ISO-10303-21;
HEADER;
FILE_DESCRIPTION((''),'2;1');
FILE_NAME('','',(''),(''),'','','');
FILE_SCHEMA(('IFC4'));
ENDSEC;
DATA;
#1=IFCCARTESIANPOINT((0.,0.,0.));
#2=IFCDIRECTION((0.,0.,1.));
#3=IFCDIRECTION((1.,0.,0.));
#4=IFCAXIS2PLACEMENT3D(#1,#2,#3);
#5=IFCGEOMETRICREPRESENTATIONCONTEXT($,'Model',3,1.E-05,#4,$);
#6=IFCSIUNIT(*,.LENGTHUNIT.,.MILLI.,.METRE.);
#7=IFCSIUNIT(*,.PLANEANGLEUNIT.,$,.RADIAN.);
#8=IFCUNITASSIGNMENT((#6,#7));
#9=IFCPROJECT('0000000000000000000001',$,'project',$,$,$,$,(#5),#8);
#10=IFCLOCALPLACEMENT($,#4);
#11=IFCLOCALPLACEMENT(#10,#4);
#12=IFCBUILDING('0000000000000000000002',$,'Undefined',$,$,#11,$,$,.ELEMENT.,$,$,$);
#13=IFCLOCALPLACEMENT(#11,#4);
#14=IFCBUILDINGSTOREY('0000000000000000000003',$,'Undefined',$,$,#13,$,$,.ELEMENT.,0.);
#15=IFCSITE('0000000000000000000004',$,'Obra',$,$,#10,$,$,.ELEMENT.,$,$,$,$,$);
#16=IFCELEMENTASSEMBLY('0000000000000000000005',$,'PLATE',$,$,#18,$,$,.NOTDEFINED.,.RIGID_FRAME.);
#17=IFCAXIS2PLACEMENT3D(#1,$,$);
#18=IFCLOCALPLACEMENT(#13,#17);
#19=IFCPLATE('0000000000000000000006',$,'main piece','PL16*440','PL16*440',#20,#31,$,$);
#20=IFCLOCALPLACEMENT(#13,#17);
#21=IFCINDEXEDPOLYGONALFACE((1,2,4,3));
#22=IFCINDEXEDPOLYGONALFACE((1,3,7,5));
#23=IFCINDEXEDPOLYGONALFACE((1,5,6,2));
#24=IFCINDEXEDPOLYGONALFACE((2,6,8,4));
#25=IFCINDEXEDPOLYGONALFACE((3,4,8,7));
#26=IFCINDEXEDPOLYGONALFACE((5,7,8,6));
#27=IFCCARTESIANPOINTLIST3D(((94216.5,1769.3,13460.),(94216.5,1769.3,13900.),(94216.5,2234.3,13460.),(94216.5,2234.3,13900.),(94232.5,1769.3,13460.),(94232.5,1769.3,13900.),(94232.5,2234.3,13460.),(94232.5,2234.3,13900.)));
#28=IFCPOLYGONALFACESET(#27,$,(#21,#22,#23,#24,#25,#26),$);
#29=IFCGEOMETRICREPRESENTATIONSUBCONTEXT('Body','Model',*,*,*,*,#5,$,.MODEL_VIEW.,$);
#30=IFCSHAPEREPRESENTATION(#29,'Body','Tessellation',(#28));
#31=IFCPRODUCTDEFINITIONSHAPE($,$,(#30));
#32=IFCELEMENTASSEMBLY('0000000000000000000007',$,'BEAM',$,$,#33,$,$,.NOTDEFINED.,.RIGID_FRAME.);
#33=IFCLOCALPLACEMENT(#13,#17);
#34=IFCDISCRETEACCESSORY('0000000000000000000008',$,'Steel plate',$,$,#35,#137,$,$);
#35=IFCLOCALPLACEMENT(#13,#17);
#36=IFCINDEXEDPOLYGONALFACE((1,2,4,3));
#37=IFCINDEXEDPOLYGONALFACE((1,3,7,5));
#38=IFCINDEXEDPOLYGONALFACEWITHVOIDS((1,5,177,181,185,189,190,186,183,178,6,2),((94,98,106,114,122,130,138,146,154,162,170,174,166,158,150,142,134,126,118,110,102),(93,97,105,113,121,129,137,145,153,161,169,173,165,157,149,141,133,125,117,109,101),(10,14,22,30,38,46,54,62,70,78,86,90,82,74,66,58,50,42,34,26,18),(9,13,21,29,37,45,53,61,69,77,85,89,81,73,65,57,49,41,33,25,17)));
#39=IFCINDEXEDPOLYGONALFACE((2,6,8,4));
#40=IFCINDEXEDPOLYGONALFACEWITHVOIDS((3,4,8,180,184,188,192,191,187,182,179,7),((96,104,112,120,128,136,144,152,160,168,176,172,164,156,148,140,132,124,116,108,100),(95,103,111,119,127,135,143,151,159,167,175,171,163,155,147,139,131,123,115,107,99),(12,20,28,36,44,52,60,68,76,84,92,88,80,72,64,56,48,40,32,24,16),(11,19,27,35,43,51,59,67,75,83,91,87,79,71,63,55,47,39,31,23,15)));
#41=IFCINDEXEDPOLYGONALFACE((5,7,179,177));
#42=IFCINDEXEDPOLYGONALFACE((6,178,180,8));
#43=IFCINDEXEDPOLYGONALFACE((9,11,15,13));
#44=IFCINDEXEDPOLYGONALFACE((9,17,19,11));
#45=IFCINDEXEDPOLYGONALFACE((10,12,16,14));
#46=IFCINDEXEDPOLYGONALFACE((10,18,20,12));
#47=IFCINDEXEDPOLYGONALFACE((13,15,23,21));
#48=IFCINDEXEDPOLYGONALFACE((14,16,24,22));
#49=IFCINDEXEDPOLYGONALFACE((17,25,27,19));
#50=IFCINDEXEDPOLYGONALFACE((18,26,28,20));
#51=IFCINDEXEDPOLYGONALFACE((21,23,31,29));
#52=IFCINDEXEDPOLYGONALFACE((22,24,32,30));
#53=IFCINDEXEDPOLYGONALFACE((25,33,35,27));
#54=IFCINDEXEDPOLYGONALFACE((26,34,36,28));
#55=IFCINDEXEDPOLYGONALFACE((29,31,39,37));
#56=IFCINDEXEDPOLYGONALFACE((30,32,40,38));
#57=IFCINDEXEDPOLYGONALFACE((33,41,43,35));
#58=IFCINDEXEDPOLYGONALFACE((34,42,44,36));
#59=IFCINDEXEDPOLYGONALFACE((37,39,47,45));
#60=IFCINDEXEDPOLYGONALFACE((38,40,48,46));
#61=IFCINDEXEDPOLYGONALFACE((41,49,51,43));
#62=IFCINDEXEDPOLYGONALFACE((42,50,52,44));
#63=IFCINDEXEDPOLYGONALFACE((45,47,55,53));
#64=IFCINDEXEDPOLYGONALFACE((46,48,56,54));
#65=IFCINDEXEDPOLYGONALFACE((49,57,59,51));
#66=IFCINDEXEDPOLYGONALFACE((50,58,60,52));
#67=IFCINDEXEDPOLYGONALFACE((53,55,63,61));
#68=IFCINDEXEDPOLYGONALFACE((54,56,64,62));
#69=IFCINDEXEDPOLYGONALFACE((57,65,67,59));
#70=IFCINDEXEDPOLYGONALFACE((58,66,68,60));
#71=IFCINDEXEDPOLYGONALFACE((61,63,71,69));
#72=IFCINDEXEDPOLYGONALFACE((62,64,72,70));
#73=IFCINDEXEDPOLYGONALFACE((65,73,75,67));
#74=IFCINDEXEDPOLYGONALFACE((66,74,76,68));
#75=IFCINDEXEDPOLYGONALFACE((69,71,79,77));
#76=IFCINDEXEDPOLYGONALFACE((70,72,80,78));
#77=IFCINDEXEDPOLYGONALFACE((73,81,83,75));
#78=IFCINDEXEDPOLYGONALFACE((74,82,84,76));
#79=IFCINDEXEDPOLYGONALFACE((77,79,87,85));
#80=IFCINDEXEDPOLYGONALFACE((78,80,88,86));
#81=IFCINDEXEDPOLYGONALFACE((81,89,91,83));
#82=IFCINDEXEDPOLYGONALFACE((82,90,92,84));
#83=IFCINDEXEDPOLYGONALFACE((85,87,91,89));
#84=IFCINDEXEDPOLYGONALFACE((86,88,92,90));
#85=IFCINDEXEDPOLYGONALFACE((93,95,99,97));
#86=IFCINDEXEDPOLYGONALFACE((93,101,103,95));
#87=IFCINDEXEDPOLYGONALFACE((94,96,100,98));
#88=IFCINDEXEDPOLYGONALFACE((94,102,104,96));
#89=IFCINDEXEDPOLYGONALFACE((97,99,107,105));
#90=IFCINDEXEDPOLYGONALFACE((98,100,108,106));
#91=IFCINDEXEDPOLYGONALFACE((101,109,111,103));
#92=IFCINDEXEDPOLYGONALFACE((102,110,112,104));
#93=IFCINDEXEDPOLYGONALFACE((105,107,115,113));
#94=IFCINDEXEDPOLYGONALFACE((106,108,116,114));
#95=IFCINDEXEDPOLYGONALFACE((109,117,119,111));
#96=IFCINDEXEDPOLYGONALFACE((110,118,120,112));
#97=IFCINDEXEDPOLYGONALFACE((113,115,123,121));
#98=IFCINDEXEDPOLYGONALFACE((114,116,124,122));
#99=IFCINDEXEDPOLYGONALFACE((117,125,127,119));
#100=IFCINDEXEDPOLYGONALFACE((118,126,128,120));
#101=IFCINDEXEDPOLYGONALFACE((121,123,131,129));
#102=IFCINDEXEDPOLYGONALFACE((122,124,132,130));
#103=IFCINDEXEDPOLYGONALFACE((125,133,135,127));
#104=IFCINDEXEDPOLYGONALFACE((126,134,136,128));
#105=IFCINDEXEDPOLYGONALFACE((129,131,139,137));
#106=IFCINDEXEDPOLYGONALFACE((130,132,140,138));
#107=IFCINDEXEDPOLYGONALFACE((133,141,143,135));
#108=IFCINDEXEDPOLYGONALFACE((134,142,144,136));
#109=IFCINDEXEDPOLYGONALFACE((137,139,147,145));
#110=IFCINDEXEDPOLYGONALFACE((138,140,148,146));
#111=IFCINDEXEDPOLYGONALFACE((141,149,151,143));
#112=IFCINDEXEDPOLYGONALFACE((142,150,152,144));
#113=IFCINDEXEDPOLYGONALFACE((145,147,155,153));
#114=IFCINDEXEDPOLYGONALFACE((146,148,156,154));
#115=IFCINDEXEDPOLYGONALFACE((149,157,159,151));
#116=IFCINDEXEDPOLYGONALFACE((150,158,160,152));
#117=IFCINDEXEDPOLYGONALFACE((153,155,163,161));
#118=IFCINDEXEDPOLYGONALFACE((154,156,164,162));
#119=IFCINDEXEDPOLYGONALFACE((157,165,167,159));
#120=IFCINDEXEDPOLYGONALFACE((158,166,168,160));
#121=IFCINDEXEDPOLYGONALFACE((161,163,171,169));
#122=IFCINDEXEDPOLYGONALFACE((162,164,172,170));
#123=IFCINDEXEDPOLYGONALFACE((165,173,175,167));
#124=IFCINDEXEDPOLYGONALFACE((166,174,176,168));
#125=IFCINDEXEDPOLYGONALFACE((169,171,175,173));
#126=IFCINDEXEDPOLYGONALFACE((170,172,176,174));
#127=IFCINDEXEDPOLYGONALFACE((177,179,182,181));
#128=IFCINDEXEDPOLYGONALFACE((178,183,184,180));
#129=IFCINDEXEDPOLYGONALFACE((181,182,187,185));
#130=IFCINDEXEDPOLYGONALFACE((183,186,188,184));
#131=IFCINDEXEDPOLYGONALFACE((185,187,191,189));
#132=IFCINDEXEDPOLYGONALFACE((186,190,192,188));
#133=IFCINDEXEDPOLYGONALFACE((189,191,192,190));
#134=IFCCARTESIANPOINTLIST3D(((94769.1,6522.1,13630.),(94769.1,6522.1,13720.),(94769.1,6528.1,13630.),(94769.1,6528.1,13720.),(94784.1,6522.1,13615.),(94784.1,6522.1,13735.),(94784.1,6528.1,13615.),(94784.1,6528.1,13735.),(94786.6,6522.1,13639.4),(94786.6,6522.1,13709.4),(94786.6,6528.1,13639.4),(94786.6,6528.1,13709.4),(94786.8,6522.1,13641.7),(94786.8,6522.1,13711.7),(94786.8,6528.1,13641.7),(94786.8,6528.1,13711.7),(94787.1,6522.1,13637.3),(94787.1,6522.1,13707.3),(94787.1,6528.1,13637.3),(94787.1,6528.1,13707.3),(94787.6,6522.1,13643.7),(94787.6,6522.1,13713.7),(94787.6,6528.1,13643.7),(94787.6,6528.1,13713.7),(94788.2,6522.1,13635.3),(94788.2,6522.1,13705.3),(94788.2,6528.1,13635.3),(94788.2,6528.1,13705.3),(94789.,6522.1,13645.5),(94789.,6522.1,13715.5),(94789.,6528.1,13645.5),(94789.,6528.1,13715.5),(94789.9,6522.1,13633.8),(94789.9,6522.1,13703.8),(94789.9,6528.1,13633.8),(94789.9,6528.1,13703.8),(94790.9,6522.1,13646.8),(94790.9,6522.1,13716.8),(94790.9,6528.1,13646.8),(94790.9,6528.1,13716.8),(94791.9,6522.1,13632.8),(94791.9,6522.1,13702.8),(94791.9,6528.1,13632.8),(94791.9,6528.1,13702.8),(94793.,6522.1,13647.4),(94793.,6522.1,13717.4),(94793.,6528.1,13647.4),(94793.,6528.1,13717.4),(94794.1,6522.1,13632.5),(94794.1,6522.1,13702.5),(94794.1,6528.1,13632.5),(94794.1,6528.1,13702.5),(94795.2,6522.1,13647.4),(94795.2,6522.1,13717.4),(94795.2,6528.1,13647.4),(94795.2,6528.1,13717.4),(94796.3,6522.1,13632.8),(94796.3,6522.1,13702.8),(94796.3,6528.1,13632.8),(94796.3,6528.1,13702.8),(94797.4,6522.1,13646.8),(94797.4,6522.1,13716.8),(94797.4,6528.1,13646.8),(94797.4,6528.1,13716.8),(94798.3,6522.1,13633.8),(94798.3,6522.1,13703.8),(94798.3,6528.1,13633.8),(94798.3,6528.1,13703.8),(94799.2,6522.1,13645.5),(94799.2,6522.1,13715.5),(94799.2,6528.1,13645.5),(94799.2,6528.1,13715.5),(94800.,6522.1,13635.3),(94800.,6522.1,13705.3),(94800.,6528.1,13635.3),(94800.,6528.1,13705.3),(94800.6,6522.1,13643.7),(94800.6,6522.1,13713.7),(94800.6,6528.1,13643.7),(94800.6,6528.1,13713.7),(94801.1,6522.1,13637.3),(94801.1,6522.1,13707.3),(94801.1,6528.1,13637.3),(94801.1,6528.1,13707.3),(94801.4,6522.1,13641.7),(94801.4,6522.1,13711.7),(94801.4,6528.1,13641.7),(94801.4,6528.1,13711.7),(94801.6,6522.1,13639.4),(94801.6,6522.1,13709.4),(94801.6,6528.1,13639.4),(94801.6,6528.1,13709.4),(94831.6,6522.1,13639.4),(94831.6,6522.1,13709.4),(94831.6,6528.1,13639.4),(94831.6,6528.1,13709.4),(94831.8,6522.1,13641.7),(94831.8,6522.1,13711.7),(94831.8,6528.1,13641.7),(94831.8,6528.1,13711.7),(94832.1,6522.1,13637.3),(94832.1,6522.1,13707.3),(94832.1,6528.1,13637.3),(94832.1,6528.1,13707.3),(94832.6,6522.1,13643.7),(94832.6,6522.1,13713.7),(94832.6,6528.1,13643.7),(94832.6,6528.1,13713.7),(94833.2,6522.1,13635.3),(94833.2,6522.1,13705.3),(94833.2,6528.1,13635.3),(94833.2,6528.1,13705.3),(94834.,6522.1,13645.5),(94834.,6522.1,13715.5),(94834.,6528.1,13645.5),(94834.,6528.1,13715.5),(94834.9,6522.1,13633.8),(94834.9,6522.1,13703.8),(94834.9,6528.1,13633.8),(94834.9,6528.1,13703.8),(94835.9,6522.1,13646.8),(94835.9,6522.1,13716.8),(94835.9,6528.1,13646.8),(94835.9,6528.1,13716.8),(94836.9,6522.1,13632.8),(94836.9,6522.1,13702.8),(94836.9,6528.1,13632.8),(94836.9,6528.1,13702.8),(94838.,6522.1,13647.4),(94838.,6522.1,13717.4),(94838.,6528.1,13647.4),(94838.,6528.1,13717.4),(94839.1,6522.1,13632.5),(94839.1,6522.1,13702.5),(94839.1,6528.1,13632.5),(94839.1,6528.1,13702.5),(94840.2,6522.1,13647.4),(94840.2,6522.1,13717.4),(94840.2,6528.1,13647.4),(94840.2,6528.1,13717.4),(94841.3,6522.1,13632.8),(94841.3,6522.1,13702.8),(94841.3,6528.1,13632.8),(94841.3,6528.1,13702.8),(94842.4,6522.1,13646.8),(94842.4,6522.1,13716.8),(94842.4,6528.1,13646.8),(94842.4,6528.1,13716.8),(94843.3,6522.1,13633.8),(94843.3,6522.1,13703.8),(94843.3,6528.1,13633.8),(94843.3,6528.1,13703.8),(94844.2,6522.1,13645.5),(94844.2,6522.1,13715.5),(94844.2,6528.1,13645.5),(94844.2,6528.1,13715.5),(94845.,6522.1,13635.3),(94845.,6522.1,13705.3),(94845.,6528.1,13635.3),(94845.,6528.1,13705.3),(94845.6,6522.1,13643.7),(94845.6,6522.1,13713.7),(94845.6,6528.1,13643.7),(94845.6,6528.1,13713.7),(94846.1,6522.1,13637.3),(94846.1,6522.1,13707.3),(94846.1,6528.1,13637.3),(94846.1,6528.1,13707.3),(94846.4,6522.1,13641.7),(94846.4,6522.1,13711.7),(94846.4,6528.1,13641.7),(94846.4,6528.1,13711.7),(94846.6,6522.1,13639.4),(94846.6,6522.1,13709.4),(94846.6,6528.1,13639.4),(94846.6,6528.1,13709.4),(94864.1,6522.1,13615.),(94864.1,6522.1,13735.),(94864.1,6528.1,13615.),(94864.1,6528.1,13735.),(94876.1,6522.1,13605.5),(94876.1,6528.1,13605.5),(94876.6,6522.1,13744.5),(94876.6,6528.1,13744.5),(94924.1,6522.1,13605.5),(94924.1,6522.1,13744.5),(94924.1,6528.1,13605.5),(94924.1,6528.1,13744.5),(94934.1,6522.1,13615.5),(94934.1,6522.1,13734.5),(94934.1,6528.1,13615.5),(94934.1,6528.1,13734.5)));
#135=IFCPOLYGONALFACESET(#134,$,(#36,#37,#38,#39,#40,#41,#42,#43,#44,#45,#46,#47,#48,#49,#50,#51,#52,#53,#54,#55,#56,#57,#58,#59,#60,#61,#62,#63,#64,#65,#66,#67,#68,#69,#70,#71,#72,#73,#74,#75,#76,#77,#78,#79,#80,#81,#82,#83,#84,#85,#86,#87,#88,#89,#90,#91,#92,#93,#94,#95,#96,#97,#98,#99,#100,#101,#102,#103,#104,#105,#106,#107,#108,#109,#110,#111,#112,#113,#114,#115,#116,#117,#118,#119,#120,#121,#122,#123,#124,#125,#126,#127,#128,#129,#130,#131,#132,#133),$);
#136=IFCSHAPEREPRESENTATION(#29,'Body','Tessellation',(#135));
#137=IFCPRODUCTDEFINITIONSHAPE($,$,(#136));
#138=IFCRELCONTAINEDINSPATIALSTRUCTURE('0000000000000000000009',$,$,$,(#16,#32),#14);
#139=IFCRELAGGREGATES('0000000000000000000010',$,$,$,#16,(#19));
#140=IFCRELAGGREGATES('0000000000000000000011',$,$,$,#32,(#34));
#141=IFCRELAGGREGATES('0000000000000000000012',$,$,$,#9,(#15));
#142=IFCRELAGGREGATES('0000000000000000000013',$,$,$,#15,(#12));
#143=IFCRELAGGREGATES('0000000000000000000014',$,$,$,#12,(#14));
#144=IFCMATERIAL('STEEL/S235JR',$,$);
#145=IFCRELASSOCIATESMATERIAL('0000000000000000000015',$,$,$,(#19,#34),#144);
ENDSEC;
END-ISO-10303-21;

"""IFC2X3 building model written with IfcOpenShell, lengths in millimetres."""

from ifc_helpers import new_model, si_unit, frame, origin_with_axes, origin_2d_with_axis, place, context, subcontext, project, spatial, polyline, circle, outline, extrude, source, transform, mapped, material, element, aggregate, save


model = new_model("IFC2X3")

# Units and contexts
model_context = context("Model", 3, precision=1e-05, world=origin_with_axes())
body_context = subcontext(model_context, "Body", "Model", "MODEL_VIEW")
ifc_project = project(units=[si_unit("LENGTHUNIT", "METRE", prefix="MILLI"), si_unit("PLANEANGLEUNIT", "RADIAN")], contexts=[model_context])

# Site, building, storey
site_placement = place(None, origin_with_axes())
site = spatial("IfcSite", under=ifc_project, at=site_placement, Name="Obra", CompositionType="ELEMENT")
building_placement = place(site_placement, origin_with_axes())
building = spatial("IfcBuilding", under=site, at=building_placement, Name="Undefined", CompositionType="ELEMENT")
storey_placement = place(building_placement, origin_with_axes())
storey = spatial("IfcBuildingStorey", under=building, at=storey_placement, Name="Undefined", CompositionType="ELEMENT", Elevation=0.0)

# Shared definitions
ifc_material_1 = material(Name="STEEL/S235JR")

# Element assembly, plate
assembly_1_placement = place(storey_placement, origin_with_axes())
assembly_1 = element("IfcElementAssembly", 1, at=assembly_1_placement, inside=storey, Name="PLATE", AssemblyPlace="NOTDEFINED", PredefinedType="RIGID_FRAME")
plate_placement = place(assembly_1_placement, frame((94224.5, 1769.3, 13460.0), z_axis=(1.0, 0.000001, 0.0), x_axis=(-0.000001, 1.0, 0.0)))
plate = element("IfcPlate", 2, at=plate_placement, material=ifc_material_1, Name="main piece", Description="PL16*440", ObjectType="PL16*440", context=body_context, shape_type="SweptSolid", body=[
    extrude(outline(polyline([(0.0, 0.0), (465.0, 0.0), (465.0, 440.0), (0.0, 440.0), (0.0, 0.0), (0.0, 0.0)])), frame((0.0, 0.0, -8.0), z_axis=(0.0, 0.0, 1.0), x_axis=(1.0, 0.0, 0.0)), (0.0, 0.0, 1.0), 16.0),
])
aggregate(assembly_1, [plate])

# Element assembly
assembly_2_placement = place(storey_placement, origin_with_axes())
assembly_2 = element("IfcElementAssembly", 3, at=assembly_2_placement, inside=storey, Name="BEAM", AssemblyPlace="NOTDEFINED", PredefinedType="RIGID_FRAME")

# Discrete accessory, opening
discrete_accessory_1_placement = place(assembly_2_placement, frame((94934.1, 6525.1, 13615.5), z_axis=(0.0, 1.0, 0.0), x_axis=(-0.707107, 0.0, -0.707107)))
discrete_accessory_1 = element("IfcDiscreteAccessory", 4, at=discrete_accessory_1_placement, material=ifc_material_1, Name="Steel plate", context=body_context, shape_type="SweptSolid", body=[
    extrude(outline(polyline([(0.0, 0.0), (14.1, 0.0), (48.1, 33.9), (49.9, 49.1), (106.4, 105.7), (106.4, 126.9), (42.8, 190.6), (21.6, 190.6), (-35.0, 134.0), (-50.6, 131.9), (-84.1, 98.3), (-84.1, 84.1), (0.0, 0.0)])), frame((0.0, 0.0, -3.0), z_axis=(0.0, 0.0, 1.0), x_axis=(1.0, 0.0, 0.0)), (0.0, 0.0, 1.0), 6.0),
])
shared_shape_1 = source(origin_with_axes(), body_context, "Body", "SweptSolid", [
    extrude(circle(Radius=7.5, at=origin_2d_with_axis()), frame((0.0, 2.4, 0.0), z_axis=(0.0, 1.0, 0.0), x_axis=(1.0, 0.0, 0.0)), (0.0, 0.0, 1.0), 6.2),
])
opening_1_placement = place(assembly_2_placement, frame((94816.6, 6530.6, 13710.0), z_axis=(-1.0, 0.0, 0.0), x_axis=(0.0, 0.0, -1.0)))
element("IfcOpeningElement", 5, at=opening_1_placement, cuts=discrete_accessory_1, ObjectType="Opening", context=body_context, shape_type="MappedRepresentation", body=[
    mapped(shared_shape_1, transform((0.0, 0.0, -22.5))),
    mapped(shared_shape_1, transform((70.0, 0.0, -22.5))),
    mapped(shared_shape_1, transform((0.0, 0.0, 22.5))),
    mapped(shared_shape_1, transform((70.0, 0.0, 22.5))),
])

aggregate(assembly_2, [discrete_accessory_1])

save(model, "model.ifc")
